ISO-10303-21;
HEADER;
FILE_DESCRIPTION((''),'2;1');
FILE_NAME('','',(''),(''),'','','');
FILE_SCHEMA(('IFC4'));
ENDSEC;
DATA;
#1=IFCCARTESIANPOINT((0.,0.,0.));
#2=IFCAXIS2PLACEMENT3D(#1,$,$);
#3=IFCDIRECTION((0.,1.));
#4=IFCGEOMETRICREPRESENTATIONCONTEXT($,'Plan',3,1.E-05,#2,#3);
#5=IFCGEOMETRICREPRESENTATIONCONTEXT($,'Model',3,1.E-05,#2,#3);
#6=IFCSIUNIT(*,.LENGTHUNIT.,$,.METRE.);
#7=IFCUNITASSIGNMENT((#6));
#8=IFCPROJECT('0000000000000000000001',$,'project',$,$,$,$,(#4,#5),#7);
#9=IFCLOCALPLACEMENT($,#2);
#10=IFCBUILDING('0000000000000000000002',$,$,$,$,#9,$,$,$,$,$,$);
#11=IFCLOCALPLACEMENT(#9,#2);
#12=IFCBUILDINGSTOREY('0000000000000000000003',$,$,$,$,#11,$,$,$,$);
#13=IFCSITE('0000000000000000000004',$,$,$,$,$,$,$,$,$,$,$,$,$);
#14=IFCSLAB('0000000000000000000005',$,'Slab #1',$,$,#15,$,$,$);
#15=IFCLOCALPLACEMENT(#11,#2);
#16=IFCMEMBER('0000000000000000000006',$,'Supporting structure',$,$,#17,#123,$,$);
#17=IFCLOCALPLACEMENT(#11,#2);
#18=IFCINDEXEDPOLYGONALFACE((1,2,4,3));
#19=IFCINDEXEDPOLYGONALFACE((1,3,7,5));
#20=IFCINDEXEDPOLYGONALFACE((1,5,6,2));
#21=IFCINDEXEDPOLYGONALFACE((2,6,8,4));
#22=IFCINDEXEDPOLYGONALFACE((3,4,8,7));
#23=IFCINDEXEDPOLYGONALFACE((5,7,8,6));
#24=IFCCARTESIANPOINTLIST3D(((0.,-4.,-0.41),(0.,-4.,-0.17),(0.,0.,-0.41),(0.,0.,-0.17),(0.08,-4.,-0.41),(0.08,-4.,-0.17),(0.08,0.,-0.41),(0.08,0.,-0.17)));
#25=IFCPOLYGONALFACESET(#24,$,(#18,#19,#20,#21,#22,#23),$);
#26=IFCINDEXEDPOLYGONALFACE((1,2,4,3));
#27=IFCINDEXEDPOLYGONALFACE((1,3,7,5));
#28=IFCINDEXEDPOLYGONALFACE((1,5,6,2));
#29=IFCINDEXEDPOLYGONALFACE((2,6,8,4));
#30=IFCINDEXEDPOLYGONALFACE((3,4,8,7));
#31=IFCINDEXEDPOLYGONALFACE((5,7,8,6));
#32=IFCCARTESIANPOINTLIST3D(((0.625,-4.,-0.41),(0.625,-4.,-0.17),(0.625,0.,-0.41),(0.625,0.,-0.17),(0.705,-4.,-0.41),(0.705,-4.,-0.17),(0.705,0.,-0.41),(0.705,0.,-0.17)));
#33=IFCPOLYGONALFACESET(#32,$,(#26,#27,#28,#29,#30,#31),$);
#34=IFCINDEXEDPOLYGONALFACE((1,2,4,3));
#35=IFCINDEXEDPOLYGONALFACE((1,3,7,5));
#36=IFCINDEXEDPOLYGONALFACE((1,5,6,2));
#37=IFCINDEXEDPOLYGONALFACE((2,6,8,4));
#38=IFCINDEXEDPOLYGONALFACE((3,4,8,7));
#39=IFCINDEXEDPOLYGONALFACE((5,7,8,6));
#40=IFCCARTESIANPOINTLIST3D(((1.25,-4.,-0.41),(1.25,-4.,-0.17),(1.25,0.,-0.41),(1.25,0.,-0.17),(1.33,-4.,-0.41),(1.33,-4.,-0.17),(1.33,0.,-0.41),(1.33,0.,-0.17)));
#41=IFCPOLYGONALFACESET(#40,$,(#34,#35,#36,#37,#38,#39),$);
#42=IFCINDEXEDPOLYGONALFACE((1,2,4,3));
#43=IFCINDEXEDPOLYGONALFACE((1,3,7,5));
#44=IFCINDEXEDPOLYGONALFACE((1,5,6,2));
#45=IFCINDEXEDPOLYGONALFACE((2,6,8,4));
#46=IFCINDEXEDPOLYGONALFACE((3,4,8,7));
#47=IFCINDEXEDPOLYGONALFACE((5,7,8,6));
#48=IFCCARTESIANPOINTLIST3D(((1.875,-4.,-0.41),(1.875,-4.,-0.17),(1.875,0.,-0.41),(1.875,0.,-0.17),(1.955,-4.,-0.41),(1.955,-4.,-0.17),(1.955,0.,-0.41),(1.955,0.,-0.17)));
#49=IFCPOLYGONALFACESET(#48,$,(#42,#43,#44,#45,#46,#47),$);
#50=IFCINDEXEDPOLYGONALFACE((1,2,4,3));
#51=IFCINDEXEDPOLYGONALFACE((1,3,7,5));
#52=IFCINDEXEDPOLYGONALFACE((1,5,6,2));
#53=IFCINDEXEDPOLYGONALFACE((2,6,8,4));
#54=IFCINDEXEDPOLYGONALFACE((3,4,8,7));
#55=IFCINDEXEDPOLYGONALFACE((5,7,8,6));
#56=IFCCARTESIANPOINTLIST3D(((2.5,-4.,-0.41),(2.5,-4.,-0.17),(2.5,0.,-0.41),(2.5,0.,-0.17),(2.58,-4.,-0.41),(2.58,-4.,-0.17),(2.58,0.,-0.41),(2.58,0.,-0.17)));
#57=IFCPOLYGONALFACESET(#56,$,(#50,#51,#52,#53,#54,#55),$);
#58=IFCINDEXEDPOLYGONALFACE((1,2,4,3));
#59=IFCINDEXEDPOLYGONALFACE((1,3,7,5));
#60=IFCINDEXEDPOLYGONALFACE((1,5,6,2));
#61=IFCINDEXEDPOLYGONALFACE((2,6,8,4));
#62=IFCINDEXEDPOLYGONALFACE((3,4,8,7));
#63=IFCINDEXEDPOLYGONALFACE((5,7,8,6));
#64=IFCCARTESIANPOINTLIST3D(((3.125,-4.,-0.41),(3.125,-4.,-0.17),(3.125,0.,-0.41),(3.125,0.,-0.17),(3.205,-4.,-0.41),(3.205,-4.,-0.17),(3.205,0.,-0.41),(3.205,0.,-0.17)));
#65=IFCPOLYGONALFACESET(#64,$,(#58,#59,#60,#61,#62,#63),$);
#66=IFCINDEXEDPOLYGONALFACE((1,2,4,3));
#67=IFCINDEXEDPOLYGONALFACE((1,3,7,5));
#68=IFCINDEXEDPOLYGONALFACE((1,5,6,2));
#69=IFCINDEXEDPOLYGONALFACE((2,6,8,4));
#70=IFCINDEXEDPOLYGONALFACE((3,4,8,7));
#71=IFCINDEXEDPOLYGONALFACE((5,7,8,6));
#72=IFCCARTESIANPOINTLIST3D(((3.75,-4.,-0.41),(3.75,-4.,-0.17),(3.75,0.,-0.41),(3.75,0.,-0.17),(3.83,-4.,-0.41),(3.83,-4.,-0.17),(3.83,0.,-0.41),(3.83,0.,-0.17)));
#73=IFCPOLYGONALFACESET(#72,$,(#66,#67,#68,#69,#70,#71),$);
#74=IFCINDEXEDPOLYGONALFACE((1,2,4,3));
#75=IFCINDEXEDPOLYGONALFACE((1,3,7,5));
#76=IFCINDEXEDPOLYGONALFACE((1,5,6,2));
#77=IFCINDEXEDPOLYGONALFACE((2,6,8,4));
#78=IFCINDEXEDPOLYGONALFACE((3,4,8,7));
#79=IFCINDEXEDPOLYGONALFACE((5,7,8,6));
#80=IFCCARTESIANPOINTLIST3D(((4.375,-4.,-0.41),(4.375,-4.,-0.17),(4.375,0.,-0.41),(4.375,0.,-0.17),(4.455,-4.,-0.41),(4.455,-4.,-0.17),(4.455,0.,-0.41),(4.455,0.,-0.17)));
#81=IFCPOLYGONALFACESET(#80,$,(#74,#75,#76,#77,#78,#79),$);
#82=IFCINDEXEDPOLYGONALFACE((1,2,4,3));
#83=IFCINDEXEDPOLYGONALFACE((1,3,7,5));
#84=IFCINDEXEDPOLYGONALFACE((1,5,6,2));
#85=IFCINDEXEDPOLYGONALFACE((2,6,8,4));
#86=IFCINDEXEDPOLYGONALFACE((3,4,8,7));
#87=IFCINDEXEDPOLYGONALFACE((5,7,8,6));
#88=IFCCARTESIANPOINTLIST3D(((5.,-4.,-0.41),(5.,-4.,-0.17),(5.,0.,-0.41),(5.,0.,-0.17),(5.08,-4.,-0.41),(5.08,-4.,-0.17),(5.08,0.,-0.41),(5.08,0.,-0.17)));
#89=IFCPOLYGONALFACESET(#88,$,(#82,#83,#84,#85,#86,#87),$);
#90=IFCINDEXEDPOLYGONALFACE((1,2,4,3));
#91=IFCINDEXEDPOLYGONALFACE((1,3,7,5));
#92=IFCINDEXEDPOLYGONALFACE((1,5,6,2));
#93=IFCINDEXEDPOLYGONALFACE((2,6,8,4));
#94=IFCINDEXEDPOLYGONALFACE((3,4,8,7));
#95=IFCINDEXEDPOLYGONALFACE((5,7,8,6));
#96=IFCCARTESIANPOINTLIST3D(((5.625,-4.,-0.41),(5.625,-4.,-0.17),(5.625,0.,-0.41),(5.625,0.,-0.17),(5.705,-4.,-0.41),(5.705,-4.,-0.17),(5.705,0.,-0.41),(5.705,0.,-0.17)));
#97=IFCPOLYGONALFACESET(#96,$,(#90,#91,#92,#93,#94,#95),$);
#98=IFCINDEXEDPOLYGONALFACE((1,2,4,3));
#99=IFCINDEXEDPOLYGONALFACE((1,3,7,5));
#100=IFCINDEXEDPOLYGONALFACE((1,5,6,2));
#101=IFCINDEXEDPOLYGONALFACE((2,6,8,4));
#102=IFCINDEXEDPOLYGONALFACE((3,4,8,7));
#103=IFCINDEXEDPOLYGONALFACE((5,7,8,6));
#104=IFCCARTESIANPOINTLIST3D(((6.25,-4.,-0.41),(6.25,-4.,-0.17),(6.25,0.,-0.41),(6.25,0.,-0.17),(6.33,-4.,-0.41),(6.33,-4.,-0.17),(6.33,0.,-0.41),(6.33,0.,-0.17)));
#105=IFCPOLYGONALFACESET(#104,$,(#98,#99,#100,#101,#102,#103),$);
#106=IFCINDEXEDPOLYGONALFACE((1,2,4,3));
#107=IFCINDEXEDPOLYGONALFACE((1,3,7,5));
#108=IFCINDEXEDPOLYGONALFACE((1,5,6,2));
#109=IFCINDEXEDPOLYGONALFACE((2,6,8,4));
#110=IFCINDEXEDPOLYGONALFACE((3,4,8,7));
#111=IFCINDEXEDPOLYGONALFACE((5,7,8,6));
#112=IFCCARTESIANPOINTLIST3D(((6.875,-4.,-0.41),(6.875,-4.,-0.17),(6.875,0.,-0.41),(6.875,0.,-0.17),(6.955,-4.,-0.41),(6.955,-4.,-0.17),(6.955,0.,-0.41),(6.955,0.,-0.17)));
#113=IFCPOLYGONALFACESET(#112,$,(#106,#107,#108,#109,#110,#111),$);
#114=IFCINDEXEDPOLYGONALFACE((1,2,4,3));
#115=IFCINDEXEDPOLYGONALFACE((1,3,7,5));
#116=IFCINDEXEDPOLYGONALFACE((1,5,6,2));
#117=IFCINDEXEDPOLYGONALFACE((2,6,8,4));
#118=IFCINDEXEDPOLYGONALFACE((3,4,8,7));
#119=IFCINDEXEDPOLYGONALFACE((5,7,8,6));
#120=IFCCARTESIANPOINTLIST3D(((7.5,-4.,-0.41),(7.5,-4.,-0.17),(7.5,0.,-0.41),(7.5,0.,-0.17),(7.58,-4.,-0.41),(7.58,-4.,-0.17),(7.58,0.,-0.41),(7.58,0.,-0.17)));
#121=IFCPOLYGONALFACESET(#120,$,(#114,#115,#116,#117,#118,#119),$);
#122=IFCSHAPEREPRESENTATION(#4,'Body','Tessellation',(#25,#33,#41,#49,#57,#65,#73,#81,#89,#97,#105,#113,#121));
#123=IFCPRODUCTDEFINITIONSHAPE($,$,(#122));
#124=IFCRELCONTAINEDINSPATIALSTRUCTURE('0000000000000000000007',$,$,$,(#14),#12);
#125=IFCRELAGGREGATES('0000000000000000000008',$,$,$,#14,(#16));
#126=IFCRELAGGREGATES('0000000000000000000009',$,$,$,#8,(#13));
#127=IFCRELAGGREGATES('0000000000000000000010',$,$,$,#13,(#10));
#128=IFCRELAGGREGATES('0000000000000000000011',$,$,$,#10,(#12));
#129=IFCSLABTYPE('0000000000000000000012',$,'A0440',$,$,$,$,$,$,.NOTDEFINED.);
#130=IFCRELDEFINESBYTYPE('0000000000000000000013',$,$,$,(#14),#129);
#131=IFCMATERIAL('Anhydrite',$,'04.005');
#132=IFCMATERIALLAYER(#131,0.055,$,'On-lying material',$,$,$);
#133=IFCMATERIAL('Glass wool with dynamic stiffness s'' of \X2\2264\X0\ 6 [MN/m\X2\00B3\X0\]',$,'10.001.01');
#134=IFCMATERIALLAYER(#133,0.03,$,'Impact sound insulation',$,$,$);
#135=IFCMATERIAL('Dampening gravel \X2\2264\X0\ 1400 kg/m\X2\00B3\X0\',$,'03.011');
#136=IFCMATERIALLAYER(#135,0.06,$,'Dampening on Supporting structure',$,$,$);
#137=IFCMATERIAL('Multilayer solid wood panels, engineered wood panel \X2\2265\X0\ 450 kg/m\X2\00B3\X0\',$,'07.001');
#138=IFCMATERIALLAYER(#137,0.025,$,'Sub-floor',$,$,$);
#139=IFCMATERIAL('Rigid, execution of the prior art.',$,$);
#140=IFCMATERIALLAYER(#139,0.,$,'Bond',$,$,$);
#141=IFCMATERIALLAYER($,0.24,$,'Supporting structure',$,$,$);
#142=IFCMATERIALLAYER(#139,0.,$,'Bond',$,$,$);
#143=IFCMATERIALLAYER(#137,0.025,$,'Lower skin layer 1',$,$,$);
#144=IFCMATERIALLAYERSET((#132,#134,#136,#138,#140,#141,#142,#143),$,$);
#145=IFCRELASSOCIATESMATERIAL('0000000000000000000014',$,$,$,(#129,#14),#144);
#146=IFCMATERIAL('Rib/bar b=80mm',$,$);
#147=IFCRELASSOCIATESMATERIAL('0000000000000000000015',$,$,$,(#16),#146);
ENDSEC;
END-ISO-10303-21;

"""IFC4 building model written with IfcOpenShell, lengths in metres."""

from ifc_helpers import new_model, si_unit, direction, frame, frame_2d, origin, place, context, project, spatial, rectangle, extrude, material, layer, layer_set, type_object, element, aggregate, save


model = new_model("IFC4")

# Units and contexts
plan_context = context("Plan", 3, precision=1e-05, world=origin(), true_north=direction((0.0, 1.0)))
model_context = context("Model", 3, precision=1e-05, world=origin(), true_north=direction((0.0, 1.0)))
ifc_project = project(units=[si_unit("LENGTHUNIT", "METRE")], contexts=[plan_context, model_context])

# Site, building, storey
site = spatial("IfcSite", under=ifc_project)
building_placement = place(None, origin())
building = spatial("IfcBuilding", under=site, at=building_placement)
storey_placement = place(building_placement, origin())
storey = spatial("IfcBuildingStorey", under=building, at=storey_placement)

# Slab, member
ifc_material_1 = material(Name="Anhydrite", Category="04.005")
ifc_layer_1 = layer(ifc_material_1, 0.055, Name="On-lying material")
ifc_material_2 = material(Name="Glass wool with dynamic stiffness s' of ≤ 6 [MN/m³]", Category="10.001.01")
ifc_layer_2 = layer(ifc_material_2, 0.03, Name="Impact sound insulation")
ifc_material_3 = material(Name="Dampening gravel ≤ 1400 kg/m³", Category="03.011")
ifc_layer_3 = layer(ifc_material_3, 0.06, Name="Dampening on Supporting structure")
ifc_material_4 = material(Name="Multilayer solid wood panels, engineered wood panel ≥ 450 kg/m³", Category="07.001")
ifc_layer_4 = layer(ifc_material_4, 0.025, Name="Sub-floor")
ifc_material_5 = material(Name="Rigid, execution of the prior art.")
ifc_layer_5 = layer(ifc_material_5, 0.0, Name="Bond")
ifc_layer_6 = layer(None, 0.24, Name="Supporting structure")
ifc_layer_7 = layer(ifc_material_5, 0.0, Name="Bond")
ifc_layer_8 = layer(ifc_material_4, 0.025, Name="Lower skin layer 1")
ifc_layer_set = layer_set([ifc_layer_1, ifc_layer_2, ifc_layer_3, ifc_layer_4, ifc_layer_5, ifc_layer_6, ifc_layer_7, ifc_layer_8])
slab_type = type_object("IfcSlabType", Name="A0440", PredefinedType="NOTDEFINED", material=ifc_layer_set)
slab_placement = place(None, frame((0.0, 0.0, 0.0), z_axis=(0.0, 0.0, -1.0), x_axis=(1.0, 0.0, 0.0)))
slab = element("IfcSlab", 1, at=slab_placement, inside=storey, type_object=slab_type, material=ifc_layer_set, Name="Slab #1")
ifc_material_6 = material(Name="Rib/bar b=80mm")
member_1_placement = place(slab_placement, origin())
member_1 = element("IfcMember", 2, at=member_1_placement, material=ifc_material_6, Name="Supporting structure", context=plan_context, shape_type="SweptSolid", body=[
    extrude(rectangle(XDim=0.08, YDim=0.24, at=frame_2d((0.04, 0.12), x_axis=(1.0, 0.0))), frame((0.0, 4.0, 0.17), z_axis=(0.0, -1.0, 0.0), x_axis=(1.0, 0.0, 0.0)), (0.0, 0.0, 1.0), 4.0),
    extrude(rectangle(XDim=0.08, YDim=0.24, at=frame_2d((0.04, 0.12), x_axis=(1.0, 0.0))), frame((0.625, 4.0, 0.17), z_axis=(0.0, -1.0, 0.0), x_axis=(1.0, 0.0, 0.0)), (0.0, 0.0, 1.0), 4.0),
    extrude(rectangle(XDim=0.08, YDim=0.24, at=frame_2d((0.04, 0.12), x_axis=(1.0, 0.0))), frame((1.25, 4.0, 0.17), z_axis=(0.0, -1.0, 0.0), x_axis=(1.0, 0.0, 0.0)), (0.0, 0.0, 1.0), 4.0),
    extrude(rectangle(XDim=0.08, YDim=0.24, at=frame_2d((0.04, 0.12), x_axis=(1.0, 0.0))), frame((1.875, 4.0, 0.17), z_axis=(0.0, -1.0, 0.0), x_axis=(1.0, 0.0, 0.0)), (0.0, 0.0, 1.0), 4.0),
    extrude(rectangle(XDim=0.08, YDim=0.24, at=frame_2d((0.04, 0.12), x_axis=(1.0, 0.0))), frame((2.5, 4.0, 0.17), z_axis=(0.0, -1.0, 0.0), x_axis=(1.0, 0.0, 0.0)), (0.0, 0.0, 1.0), 4.0),
    extrude(rectangle(XDim=0.08, YDim=0.24, at=frame_2d((0.04, 0.12), x_axis=(1.0, 0.0))), frame((3.125, 4.0, 0.17), z_axis=(0.0, -1.0, 0.0), x_axis=(1.0, 0.0, 0.0)), (0.0, 0.0, 1.0), 4.0),
    extrude(rectangle(XDim=0.08, YDim=0.24, at=frame_2d((0.04, 0.12), x_axis=(1.0, 0.0))), frame((3.75, 4.0, 0.17), z_axis=(0.0, -1.0, 0.0), x_axis=(1.0, 0.0, 0.0)), (0.0, 0.0, 1.0), 4.0),
    extrude(rectangle(XDim=0.08, YDim=0.24, at=frame_2d((0.04, 0.12), x_axis=(1.0, 0.0))), frame((4.375, 4.0, 0.17), z_axis=(0.0, -1.0, 0.0), x_axis=(1.0, 0.0, 0.0)), (0.0, 0.0, 1.0), 4.0),
    extrude(rectangle(XDim=0.08, YDim=0.24, at=frame_2d((0.04, 0.12), x_axis=(1.0, 0.0))), frame((5.0, 4.0, 0.17), z_axis=(0.0, -1.0, 0.0), x_axis=(1.0, 0.0, 0.0)), (0.0, 0.0, 1.0), 4.0),
    extrude(rectangle(XDim=0.08, YDim=0.24, at=frame_2d((0.04, 0.12), x_axis=(1.0, 0.0))), frame((5.625, 4.0, 0.17), z_axis=(0.0, -1.0, 0.0), x_axis=(1.0, 0.0, 0.0)), (0.0, 0.0, 1.0), 4.0),
    extrude(rectangle(XDim=0.08, YDim=0.24, at=frame_2d((0.04, 0.12), x_axis=(1.0, 0.0))), frame((6.25, 4.0, 0.17), z_axis=(0.0, -1.0, 0.0), x_axis=(1.0, 0.0, 0.0)), (0.0, 0.0, 1.0), 4.0),
    extrude(rectangle(XDim=0.08, YDim=0.24, at=frame_2d((0.04, 0.12), x_axis=(1.0, 0.0))), frame((6.875, 4.0, 0.17), z_axis=(0.0, -1.0, 0.0), x_axis=(1.0, 0.0, 0.0)), (0.0, 0.0, 1.0), 4.0),
    extrude(rectangle(XDim=0.08, YDim=0.24, at=frame_2d((0.04, 0.12), x_axis=(1.0, 0.0))), frame((7.5, 4.0, 0.17), z_axis=(0.0, -1.0, 0.0), x_axis=(1.0, 0.0, 0.0)), (0.0, 0.0, 1.0), 4.0),
])
aggregate(slab, [member_1])

save(model, "model.ifc")
